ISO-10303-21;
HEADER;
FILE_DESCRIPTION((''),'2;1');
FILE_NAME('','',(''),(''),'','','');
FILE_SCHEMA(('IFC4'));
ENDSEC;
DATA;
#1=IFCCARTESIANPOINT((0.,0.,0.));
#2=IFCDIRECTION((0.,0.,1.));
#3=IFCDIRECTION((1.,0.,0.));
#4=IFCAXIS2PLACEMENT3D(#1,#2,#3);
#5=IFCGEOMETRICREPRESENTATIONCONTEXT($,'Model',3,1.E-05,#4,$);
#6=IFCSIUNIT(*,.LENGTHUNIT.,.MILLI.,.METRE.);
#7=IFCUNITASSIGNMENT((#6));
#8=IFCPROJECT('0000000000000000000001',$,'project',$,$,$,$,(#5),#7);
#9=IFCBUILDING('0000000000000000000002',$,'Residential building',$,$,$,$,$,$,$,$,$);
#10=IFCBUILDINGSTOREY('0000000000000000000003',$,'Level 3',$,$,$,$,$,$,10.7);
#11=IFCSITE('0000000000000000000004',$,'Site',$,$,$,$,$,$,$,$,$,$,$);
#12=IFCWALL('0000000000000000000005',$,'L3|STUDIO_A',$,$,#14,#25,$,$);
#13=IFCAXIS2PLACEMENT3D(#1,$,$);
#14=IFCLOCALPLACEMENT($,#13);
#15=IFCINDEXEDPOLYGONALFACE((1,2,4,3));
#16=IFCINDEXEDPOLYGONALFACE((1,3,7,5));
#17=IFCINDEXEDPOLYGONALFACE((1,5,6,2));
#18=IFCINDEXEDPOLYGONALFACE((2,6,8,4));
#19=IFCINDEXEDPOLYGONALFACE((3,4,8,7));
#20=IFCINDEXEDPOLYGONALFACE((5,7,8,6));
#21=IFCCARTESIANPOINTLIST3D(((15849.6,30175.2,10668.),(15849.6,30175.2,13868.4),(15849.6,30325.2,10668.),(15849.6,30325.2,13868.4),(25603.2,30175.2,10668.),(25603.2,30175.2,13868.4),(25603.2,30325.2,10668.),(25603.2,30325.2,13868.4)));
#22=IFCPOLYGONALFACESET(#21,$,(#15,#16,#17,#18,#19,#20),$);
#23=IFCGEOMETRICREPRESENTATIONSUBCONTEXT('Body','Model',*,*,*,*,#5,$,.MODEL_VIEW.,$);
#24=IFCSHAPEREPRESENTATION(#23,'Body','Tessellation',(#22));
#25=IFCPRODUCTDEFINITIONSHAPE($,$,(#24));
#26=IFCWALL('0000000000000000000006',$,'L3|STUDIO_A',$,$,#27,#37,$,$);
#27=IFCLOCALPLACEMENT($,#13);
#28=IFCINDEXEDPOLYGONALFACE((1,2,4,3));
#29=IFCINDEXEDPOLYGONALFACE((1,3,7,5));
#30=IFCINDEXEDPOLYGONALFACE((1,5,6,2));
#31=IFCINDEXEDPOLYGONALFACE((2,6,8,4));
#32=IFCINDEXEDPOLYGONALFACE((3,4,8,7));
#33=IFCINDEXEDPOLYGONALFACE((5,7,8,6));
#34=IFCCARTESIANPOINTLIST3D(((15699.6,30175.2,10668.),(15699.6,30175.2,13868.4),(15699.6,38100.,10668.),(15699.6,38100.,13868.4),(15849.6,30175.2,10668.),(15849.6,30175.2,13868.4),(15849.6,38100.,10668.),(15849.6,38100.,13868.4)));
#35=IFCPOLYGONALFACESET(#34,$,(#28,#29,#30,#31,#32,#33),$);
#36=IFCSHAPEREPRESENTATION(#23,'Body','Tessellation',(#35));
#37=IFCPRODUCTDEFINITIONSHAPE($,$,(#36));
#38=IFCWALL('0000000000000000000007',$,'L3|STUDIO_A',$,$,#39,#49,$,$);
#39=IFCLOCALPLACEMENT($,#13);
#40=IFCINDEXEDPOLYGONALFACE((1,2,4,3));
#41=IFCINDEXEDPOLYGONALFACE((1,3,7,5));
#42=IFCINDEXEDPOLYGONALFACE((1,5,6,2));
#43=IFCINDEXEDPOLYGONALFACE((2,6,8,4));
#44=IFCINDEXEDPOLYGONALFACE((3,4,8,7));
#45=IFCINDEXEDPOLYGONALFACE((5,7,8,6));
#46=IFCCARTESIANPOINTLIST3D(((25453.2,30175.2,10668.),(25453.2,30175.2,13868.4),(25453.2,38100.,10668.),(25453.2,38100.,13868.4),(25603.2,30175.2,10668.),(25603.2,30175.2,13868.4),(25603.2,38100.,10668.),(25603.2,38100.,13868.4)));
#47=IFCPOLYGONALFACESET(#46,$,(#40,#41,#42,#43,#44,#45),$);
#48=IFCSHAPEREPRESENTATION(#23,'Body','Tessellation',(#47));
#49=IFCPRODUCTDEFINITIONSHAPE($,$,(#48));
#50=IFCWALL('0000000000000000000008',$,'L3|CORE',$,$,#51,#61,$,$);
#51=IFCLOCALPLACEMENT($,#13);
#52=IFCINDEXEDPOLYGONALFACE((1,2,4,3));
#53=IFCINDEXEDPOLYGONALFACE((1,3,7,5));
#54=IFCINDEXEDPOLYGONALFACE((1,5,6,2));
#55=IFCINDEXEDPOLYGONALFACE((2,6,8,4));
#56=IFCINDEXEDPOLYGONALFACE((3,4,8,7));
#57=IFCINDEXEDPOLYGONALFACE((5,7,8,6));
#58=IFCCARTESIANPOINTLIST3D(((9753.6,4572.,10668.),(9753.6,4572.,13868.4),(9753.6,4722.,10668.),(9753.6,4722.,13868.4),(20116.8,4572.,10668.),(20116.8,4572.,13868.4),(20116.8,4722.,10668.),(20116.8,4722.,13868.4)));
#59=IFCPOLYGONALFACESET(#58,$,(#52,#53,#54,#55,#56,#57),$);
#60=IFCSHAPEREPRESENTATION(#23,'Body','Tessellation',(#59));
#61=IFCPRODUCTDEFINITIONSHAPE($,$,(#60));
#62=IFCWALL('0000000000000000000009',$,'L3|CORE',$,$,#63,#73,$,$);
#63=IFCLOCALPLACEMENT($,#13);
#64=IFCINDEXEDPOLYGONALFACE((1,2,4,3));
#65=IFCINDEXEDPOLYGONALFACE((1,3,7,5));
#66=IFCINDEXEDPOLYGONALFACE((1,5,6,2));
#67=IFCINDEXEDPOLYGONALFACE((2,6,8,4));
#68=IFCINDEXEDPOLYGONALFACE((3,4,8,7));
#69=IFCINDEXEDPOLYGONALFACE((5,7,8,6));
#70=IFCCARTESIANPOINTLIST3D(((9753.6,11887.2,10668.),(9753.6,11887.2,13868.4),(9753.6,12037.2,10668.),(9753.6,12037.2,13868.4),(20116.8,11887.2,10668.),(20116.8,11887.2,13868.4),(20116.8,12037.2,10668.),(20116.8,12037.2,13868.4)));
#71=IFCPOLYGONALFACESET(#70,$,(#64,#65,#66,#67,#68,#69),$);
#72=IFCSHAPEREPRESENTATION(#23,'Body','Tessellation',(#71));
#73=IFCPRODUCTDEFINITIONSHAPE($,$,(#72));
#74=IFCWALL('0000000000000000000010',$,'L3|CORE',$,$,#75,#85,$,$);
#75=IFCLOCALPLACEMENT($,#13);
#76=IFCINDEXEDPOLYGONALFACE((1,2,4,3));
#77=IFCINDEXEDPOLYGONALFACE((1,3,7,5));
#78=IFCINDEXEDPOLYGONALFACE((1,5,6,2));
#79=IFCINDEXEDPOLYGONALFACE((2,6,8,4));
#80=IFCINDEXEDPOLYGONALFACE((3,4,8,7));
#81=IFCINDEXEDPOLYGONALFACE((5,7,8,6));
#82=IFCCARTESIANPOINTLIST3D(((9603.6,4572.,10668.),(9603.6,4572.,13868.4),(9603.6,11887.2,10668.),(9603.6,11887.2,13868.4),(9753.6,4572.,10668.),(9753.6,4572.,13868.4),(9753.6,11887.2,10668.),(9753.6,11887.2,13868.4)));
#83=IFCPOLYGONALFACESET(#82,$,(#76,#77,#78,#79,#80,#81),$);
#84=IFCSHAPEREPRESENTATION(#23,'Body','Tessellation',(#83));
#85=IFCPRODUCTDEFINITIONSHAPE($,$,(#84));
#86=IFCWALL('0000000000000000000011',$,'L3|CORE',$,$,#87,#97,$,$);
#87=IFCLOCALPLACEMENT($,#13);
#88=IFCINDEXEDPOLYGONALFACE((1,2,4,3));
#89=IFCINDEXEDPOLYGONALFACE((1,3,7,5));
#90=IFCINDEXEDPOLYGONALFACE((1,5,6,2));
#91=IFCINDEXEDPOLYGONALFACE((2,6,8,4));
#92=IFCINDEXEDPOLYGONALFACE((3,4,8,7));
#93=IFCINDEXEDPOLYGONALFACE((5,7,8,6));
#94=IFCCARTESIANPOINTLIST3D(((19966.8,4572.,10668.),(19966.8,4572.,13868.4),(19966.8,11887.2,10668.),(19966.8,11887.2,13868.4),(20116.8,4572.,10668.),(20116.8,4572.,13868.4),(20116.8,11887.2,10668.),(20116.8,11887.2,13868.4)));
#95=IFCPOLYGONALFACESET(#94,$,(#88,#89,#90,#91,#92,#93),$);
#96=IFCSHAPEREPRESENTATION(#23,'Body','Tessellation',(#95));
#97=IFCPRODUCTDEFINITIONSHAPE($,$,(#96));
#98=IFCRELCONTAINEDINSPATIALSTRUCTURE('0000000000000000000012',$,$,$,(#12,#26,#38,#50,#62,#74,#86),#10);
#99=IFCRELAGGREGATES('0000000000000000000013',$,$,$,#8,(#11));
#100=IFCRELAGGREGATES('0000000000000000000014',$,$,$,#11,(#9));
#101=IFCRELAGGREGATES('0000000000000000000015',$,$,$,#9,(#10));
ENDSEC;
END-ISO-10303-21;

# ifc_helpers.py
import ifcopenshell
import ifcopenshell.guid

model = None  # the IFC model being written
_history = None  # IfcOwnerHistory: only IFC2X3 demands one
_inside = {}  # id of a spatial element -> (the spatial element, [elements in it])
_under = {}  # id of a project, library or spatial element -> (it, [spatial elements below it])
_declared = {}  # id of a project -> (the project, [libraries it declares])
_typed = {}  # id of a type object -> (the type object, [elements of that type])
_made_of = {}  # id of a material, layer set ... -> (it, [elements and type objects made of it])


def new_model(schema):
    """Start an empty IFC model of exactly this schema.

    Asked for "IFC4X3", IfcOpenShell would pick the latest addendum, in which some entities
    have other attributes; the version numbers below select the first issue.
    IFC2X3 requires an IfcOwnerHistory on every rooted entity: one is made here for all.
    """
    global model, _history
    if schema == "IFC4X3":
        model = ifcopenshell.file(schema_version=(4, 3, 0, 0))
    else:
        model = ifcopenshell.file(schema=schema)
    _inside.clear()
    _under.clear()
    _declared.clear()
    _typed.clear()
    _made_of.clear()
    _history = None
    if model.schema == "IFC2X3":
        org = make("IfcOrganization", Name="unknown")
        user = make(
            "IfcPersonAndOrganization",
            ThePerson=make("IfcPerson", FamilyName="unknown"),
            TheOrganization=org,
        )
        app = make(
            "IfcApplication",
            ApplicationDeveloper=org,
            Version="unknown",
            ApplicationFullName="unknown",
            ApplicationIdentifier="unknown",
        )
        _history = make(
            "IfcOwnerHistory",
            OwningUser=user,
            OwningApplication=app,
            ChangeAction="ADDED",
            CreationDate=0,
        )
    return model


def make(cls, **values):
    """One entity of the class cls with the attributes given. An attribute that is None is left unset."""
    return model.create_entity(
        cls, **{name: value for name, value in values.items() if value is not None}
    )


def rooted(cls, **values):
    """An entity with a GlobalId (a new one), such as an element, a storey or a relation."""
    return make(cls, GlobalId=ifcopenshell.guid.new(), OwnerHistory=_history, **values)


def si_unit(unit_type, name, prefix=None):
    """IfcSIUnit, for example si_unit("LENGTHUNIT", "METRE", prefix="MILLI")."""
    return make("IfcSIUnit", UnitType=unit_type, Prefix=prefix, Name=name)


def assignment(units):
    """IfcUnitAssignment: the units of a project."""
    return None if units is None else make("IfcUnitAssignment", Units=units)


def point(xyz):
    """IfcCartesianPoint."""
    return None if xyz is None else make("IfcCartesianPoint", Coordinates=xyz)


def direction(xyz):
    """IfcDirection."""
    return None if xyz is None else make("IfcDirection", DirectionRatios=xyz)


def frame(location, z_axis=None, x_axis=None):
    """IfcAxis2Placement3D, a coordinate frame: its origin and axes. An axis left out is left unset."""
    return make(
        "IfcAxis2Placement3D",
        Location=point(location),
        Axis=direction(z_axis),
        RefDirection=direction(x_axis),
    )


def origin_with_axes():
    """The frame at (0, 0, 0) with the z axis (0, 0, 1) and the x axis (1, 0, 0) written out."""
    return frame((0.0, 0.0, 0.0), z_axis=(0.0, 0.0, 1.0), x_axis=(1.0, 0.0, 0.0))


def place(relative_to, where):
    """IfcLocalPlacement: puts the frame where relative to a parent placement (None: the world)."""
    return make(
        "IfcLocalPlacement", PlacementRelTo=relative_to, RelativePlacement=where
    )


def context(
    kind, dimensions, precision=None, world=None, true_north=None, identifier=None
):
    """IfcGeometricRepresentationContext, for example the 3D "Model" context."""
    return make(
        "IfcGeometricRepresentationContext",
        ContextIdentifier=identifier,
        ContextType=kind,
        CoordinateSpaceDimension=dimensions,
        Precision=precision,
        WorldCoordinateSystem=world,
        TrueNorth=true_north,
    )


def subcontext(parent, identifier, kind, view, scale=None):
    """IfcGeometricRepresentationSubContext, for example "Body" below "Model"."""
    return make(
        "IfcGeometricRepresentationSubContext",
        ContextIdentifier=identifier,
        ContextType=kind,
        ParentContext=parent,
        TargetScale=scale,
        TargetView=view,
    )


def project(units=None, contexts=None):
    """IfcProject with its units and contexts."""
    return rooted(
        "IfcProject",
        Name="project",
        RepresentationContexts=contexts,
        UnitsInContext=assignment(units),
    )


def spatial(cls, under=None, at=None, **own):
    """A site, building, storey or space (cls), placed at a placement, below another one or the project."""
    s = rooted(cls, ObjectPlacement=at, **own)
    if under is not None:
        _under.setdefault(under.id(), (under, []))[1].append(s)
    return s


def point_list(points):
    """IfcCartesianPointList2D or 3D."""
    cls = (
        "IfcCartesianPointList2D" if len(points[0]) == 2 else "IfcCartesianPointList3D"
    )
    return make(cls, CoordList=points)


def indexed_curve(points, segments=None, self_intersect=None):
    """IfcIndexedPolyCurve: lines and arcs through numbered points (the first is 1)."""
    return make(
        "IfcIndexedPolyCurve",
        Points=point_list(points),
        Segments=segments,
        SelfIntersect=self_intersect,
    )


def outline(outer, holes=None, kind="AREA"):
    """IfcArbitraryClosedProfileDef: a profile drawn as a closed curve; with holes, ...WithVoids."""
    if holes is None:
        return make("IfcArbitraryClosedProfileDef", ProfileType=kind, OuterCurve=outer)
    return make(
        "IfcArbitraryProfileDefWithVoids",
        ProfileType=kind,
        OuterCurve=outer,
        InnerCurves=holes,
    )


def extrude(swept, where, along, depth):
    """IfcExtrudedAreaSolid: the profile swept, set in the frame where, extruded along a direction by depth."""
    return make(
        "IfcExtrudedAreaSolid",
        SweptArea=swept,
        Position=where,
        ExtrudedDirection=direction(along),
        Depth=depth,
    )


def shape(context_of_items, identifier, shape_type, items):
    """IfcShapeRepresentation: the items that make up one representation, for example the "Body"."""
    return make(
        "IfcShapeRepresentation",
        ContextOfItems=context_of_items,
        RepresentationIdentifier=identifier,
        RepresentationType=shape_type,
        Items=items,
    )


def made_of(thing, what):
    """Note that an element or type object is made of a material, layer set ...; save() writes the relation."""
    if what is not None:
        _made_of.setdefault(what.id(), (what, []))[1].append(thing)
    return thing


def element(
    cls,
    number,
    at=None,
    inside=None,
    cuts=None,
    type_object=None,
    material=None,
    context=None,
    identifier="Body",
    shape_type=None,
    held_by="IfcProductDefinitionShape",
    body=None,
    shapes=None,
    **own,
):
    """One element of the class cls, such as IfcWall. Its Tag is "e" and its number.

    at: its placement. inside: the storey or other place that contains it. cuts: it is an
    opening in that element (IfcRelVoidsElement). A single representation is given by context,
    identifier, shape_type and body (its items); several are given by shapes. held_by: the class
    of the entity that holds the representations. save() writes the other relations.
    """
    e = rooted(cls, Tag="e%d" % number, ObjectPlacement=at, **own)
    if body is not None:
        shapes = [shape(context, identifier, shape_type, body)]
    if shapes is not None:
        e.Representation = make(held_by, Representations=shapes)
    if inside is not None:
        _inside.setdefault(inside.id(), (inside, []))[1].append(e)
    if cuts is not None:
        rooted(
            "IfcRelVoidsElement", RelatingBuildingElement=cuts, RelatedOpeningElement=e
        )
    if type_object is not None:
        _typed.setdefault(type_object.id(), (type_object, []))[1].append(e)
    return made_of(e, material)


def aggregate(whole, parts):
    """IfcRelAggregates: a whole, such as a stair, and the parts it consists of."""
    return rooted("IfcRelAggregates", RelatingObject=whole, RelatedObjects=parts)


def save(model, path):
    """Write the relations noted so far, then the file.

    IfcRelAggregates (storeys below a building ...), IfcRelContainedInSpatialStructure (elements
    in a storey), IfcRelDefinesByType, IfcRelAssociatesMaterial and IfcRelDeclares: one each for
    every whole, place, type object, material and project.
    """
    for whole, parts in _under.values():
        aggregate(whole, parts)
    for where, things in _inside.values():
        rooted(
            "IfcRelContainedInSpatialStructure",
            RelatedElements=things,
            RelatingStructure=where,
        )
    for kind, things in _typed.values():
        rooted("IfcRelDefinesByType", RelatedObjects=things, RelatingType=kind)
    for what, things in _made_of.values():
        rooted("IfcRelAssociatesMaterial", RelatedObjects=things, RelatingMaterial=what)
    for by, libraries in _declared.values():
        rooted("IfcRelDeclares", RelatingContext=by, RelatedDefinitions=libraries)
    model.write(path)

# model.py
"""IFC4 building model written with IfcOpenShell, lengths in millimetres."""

from ifc_helpers import new_model, si_unit, frame, origin_with_axes, place, context, subcontext, project, spatial, indexed_curve, outline, extrude, element, save


model = new_model("IFC4")

# Units and contexts
model_context = context("Model", 3, precision=1e-05, world=origin_with_axes())
body_context = subcontext(model_context, "Body", "Model", "MODEL_VIEW")
ifc_project = project(units=[si_unit("LENGTHUNIT", "METRE", prefix="MILLI")], contexts=[model_context])

# Site, building, storey
site = spatial("IfcSite", under=ifc_project, Name="Site")
building = spatial("IfcBuilding", under=site, Name="Residential building")
storey = spatial("IfcBuildingStorey", under=building, Name="Level 3", Elevation=10.7)

# Walls
wall_1_placement = place(None, frame((15849.6, 30175.2, 10668.0), z_axis=(0.0, 0.0, 1.0), x_axis=(1.0, 0.0, 0.0)))
element("IfcWall", 1, at=wall_1_placement, inside=storey, Name="L3|STUDIO_A", context=body_context, shape_type="SweptSolid", body=[
    extrude(outline(indexed_curve([(0.0, 0.0), (0.0, 150.0), (9753.6, 150.0), (9753.6, 0.0), (0.0, 0.0)], self_intersect=False)), origin_with_axes(), (0.0, 0.0, 1.0), 3200.4),
])
for number, where, z_axis, x_axis, name in (
    (2, (15849.6, 30175.2, 10668.0), (0.0, 0.0, 1.0), (0.0, 1.0, 0.0), "L3|STUDIO_A"),
    (3, (25603.2, 30175.2, 10668.0), (0.0, 0.0, 1.0), (0.0, 1.0, 0.0), "L3|STUDIO_A"),
):
    element("IfcWall", number, at=place(None, frame(where, z_axis=z_axis, x_axis=x_axis)), inside=storey, Name=name, context=body_context, shape_type="SweptSolid", body=[
        extrude(outline(indexed_curve([(0.0, 0.0), (0.0, 150.0), (7924.8, 150.0), (7924.8, 0.0), (0.0, 0.0)], self_intersect=False)), origin_with_axes(), (0.0, 0.0, 1.0), 3200.4),
    ])
for number, where, z_axis, x_axis, name in (
    (4, (9753.6, 4572.0, 10668.0), (0.0, 0.0, 1.0), (1.0, 0.0, 0.0), "L3|CORE"),
    (5, (9753.6, 11887.2, 10668.0), (0.0, 0.0, 1.0), (1.0, 0.0, 0.0), "L3|CORE"),
):
    element("IfcWall", number, at=place(None, frame(where, z_axis=z_axis, x_axis=x_axis)), inside=storey, Name=name, context=body_context, shape_type="SweptSolid", body=[
        extrude(outline(indexed_curve([(0.0, 0.0), (0.0, 150.0), (10363.2, 150.0), (10363.2, 0.0), (0.0, 0.0)], self_intersect=False)), origin_with_axes(), (0.0, 0.0, 1.0), 3200.4),
    ])
for number, where, z_axis, x_axis, name in (
    (6, (9753.6, 4572.0, 10668.0), (0.0, 0.0, 1.0), (0.0, 1.0, 0.0), "L3|CORE"),
    (7, (20116.8, 4572.0, 10668.0), (0.0, 0.0, 1.0), (0.0, 1.0, 0.0), "L3|CORE"),
):
    element("IfcWall", number, at=place(None, frame(where, z_axis=z_axis, x_axis=x_axis)), inside=storey, Name=name, context=body_context, shape_type="SweptSolid", body=[
        extrude(outline(indexed_curve([(0.0, 0.0), (0.0, 150.0), (7315.2, 150.0), (7315.2, 0.0), (0.0, 0.0)], self_intersect=False)), origin_with_axes(), (0.0, 0.0, 1.0), 3200.4),
    ])

save(model, "model.ifc")
